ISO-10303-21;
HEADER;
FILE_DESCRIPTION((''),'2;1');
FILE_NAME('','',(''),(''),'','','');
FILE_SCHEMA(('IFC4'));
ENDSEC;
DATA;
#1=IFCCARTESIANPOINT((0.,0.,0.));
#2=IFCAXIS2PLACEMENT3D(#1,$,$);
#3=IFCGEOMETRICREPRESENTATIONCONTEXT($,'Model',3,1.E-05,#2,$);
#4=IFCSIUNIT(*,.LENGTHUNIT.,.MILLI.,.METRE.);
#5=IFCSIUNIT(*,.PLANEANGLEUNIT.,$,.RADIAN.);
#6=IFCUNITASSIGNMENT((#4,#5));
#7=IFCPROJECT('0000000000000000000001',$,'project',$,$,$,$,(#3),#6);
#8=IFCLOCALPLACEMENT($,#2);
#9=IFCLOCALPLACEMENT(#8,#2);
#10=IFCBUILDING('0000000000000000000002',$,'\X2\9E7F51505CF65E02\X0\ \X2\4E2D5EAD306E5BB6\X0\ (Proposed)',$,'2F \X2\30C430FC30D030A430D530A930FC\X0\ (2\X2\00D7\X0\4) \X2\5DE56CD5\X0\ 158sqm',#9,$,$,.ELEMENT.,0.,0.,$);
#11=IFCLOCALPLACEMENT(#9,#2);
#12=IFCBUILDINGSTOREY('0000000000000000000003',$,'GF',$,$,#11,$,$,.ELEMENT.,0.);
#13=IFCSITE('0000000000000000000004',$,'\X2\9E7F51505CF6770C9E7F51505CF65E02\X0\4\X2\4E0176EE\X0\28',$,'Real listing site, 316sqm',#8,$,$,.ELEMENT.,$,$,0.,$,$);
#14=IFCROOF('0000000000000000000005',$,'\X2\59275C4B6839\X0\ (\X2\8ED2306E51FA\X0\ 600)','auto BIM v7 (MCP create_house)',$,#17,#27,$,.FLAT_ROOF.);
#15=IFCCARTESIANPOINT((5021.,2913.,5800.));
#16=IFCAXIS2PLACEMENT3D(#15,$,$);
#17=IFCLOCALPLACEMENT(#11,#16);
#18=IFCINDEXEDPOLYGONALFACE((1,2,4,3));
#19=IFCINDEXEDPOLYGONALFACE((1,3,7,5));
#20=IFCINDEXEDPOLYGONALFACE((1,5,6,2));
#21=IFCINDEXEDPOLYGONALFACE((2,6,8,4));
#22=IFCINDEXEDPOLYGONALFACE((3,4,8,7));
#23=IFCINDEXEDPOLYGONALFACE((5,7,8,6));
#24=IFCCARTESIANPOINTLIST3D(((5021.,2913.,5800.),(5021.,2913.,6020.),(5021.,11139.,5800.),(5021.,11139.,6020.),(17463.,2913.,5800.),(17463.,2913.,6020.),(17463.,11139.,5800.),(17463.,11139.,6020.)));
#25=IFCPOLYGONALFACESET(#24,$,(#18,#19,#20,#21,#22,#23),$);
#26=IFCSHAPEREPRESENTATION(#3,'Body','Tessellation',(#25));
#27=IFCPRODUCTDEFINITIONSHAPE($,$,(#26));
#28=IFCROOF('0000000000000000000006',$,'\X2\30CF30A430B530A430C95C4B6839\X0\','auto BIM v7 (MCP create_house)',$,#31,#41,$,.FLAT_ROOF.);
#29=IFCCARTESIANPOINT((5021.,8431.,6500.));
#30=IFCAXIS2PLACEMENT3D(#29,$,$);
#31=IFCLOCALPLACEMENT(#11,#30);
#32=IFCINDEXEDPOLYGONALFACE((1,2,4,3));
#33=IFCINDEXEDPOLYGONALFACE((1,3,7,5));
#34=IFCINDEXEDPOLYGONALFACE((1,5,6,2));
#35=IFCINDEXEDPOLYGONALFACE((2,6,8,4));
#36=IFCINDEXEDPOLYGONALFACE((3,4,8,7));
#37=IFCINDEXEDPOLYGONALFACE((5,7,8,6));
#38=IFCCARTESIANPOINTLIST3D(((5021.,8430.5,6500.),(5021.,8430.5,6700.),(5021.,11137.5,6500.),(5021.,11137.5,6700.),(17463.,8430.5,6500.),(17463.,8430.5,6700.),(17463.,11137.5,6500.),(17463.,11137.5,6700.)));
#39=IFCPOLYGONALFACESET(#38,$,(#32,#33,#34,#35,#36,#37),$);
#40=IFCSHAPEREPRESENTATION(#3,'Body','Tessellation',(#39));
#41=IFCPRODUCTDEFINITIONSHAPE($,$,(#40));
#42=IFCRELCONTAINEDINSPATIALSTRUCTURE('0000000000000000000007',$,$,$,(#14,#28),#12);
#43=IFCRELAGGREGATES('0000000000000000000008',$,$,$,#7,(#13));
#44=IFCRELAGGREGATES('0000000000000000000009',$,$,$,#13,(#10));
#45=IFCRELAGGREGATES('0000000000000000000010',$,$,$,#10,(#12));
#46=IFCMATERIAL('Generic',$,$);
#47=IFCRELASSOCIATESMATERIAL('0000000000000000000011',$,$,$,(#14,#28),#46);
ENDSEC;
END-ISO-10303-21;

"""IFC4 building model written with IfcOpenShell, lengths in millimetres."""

from ifc_helpers import new_model, si_unit, frame, frame_2d, origin, place, context, project, spatial, rectangle, extrude, material, element, save


model = new_model("IFC4")

# Units and contexts
model_context = context("Model", 3, precision=1e-05, world=origin())
ifc_project = project(units=[si_unit("LENGTHUNIT", "METRE", prefix="MILLI"), si_unit("PLANEANGLEUNIT", "RADIAN")], contexts=[model_context])

# Site, building, storey
site_placement = place(None, origin())
site = spatial("IfcSite", under=ifc_project, at=site_placement, Name="鹿児島県鹿児島市4丁目28", ObjectType="Real listing site, 316sqm", CompositionType="ELEMENT", RefElevation=0.0)
building_placement = place(site_placement, origin())
building = spatial("IfcBuilding", under=site, at=building_placement, Name="鹿児島市 中庭の家 (Proposed)", ObjectType="2F ツーバイフォー (2×4) 工法 158sqm", CompositionType="ELEMENT", ElevationOfRefHeight=0.0, ElevationOfTerrain=0.0)
storey_placement = place(building_placement, origin())
storey = spatial("IfcBuildingStorey", under=building, at=storey_placement, Name="GF", CompositionType="ELEMENT", Elevation=0.0)

# Shared definitions
ifc_material = material(Name="Generic")

# Roofs
roof_1_placement = place(storey_placement, frame((5021.0, 2913.0, 5800.0)))
element("IfcRoof", 1, at=roof_1_placement, inside=storey, material=ifc_material, Name="大屋根 (軒の出 600)", Description="auto BIM v7 (MCP create_house)", PredefinedType="FLAT_ROOF", context=model_context, shape_type="SweptSolid", body=[
    extrude(rectangle(XDim=12442.0, YDim=8226.0, at=frame_2d((6221.0, 4113.0))), frame((5021.0, 2913.0, 5800.0)), (0.0, 0.0, 1.0), 220.0),
])
roof_2_placement = place(storey_placement, frame((5021.0, 8431.0, 6500.0)))
element("IfcRoof", 2, at=roof_2_placement, inside=storey, material=ifc_material, Name="ハイサイド屋根", Description="auto BIM v7 (MCP create_house)", PredefinedType="FLAT_ROOF", context=model_context, shape_type="SweptSolid", body=[
    extrude(rectangle(XDim=12442.0, YDim=2707.0, at=frame_2d((6221.0, 1353.0))), frame((5021.0, 8431.0, 6500.0)), (0.0, 0.0, 1.0), 200.0),
])

save(model, "model.ifc")
